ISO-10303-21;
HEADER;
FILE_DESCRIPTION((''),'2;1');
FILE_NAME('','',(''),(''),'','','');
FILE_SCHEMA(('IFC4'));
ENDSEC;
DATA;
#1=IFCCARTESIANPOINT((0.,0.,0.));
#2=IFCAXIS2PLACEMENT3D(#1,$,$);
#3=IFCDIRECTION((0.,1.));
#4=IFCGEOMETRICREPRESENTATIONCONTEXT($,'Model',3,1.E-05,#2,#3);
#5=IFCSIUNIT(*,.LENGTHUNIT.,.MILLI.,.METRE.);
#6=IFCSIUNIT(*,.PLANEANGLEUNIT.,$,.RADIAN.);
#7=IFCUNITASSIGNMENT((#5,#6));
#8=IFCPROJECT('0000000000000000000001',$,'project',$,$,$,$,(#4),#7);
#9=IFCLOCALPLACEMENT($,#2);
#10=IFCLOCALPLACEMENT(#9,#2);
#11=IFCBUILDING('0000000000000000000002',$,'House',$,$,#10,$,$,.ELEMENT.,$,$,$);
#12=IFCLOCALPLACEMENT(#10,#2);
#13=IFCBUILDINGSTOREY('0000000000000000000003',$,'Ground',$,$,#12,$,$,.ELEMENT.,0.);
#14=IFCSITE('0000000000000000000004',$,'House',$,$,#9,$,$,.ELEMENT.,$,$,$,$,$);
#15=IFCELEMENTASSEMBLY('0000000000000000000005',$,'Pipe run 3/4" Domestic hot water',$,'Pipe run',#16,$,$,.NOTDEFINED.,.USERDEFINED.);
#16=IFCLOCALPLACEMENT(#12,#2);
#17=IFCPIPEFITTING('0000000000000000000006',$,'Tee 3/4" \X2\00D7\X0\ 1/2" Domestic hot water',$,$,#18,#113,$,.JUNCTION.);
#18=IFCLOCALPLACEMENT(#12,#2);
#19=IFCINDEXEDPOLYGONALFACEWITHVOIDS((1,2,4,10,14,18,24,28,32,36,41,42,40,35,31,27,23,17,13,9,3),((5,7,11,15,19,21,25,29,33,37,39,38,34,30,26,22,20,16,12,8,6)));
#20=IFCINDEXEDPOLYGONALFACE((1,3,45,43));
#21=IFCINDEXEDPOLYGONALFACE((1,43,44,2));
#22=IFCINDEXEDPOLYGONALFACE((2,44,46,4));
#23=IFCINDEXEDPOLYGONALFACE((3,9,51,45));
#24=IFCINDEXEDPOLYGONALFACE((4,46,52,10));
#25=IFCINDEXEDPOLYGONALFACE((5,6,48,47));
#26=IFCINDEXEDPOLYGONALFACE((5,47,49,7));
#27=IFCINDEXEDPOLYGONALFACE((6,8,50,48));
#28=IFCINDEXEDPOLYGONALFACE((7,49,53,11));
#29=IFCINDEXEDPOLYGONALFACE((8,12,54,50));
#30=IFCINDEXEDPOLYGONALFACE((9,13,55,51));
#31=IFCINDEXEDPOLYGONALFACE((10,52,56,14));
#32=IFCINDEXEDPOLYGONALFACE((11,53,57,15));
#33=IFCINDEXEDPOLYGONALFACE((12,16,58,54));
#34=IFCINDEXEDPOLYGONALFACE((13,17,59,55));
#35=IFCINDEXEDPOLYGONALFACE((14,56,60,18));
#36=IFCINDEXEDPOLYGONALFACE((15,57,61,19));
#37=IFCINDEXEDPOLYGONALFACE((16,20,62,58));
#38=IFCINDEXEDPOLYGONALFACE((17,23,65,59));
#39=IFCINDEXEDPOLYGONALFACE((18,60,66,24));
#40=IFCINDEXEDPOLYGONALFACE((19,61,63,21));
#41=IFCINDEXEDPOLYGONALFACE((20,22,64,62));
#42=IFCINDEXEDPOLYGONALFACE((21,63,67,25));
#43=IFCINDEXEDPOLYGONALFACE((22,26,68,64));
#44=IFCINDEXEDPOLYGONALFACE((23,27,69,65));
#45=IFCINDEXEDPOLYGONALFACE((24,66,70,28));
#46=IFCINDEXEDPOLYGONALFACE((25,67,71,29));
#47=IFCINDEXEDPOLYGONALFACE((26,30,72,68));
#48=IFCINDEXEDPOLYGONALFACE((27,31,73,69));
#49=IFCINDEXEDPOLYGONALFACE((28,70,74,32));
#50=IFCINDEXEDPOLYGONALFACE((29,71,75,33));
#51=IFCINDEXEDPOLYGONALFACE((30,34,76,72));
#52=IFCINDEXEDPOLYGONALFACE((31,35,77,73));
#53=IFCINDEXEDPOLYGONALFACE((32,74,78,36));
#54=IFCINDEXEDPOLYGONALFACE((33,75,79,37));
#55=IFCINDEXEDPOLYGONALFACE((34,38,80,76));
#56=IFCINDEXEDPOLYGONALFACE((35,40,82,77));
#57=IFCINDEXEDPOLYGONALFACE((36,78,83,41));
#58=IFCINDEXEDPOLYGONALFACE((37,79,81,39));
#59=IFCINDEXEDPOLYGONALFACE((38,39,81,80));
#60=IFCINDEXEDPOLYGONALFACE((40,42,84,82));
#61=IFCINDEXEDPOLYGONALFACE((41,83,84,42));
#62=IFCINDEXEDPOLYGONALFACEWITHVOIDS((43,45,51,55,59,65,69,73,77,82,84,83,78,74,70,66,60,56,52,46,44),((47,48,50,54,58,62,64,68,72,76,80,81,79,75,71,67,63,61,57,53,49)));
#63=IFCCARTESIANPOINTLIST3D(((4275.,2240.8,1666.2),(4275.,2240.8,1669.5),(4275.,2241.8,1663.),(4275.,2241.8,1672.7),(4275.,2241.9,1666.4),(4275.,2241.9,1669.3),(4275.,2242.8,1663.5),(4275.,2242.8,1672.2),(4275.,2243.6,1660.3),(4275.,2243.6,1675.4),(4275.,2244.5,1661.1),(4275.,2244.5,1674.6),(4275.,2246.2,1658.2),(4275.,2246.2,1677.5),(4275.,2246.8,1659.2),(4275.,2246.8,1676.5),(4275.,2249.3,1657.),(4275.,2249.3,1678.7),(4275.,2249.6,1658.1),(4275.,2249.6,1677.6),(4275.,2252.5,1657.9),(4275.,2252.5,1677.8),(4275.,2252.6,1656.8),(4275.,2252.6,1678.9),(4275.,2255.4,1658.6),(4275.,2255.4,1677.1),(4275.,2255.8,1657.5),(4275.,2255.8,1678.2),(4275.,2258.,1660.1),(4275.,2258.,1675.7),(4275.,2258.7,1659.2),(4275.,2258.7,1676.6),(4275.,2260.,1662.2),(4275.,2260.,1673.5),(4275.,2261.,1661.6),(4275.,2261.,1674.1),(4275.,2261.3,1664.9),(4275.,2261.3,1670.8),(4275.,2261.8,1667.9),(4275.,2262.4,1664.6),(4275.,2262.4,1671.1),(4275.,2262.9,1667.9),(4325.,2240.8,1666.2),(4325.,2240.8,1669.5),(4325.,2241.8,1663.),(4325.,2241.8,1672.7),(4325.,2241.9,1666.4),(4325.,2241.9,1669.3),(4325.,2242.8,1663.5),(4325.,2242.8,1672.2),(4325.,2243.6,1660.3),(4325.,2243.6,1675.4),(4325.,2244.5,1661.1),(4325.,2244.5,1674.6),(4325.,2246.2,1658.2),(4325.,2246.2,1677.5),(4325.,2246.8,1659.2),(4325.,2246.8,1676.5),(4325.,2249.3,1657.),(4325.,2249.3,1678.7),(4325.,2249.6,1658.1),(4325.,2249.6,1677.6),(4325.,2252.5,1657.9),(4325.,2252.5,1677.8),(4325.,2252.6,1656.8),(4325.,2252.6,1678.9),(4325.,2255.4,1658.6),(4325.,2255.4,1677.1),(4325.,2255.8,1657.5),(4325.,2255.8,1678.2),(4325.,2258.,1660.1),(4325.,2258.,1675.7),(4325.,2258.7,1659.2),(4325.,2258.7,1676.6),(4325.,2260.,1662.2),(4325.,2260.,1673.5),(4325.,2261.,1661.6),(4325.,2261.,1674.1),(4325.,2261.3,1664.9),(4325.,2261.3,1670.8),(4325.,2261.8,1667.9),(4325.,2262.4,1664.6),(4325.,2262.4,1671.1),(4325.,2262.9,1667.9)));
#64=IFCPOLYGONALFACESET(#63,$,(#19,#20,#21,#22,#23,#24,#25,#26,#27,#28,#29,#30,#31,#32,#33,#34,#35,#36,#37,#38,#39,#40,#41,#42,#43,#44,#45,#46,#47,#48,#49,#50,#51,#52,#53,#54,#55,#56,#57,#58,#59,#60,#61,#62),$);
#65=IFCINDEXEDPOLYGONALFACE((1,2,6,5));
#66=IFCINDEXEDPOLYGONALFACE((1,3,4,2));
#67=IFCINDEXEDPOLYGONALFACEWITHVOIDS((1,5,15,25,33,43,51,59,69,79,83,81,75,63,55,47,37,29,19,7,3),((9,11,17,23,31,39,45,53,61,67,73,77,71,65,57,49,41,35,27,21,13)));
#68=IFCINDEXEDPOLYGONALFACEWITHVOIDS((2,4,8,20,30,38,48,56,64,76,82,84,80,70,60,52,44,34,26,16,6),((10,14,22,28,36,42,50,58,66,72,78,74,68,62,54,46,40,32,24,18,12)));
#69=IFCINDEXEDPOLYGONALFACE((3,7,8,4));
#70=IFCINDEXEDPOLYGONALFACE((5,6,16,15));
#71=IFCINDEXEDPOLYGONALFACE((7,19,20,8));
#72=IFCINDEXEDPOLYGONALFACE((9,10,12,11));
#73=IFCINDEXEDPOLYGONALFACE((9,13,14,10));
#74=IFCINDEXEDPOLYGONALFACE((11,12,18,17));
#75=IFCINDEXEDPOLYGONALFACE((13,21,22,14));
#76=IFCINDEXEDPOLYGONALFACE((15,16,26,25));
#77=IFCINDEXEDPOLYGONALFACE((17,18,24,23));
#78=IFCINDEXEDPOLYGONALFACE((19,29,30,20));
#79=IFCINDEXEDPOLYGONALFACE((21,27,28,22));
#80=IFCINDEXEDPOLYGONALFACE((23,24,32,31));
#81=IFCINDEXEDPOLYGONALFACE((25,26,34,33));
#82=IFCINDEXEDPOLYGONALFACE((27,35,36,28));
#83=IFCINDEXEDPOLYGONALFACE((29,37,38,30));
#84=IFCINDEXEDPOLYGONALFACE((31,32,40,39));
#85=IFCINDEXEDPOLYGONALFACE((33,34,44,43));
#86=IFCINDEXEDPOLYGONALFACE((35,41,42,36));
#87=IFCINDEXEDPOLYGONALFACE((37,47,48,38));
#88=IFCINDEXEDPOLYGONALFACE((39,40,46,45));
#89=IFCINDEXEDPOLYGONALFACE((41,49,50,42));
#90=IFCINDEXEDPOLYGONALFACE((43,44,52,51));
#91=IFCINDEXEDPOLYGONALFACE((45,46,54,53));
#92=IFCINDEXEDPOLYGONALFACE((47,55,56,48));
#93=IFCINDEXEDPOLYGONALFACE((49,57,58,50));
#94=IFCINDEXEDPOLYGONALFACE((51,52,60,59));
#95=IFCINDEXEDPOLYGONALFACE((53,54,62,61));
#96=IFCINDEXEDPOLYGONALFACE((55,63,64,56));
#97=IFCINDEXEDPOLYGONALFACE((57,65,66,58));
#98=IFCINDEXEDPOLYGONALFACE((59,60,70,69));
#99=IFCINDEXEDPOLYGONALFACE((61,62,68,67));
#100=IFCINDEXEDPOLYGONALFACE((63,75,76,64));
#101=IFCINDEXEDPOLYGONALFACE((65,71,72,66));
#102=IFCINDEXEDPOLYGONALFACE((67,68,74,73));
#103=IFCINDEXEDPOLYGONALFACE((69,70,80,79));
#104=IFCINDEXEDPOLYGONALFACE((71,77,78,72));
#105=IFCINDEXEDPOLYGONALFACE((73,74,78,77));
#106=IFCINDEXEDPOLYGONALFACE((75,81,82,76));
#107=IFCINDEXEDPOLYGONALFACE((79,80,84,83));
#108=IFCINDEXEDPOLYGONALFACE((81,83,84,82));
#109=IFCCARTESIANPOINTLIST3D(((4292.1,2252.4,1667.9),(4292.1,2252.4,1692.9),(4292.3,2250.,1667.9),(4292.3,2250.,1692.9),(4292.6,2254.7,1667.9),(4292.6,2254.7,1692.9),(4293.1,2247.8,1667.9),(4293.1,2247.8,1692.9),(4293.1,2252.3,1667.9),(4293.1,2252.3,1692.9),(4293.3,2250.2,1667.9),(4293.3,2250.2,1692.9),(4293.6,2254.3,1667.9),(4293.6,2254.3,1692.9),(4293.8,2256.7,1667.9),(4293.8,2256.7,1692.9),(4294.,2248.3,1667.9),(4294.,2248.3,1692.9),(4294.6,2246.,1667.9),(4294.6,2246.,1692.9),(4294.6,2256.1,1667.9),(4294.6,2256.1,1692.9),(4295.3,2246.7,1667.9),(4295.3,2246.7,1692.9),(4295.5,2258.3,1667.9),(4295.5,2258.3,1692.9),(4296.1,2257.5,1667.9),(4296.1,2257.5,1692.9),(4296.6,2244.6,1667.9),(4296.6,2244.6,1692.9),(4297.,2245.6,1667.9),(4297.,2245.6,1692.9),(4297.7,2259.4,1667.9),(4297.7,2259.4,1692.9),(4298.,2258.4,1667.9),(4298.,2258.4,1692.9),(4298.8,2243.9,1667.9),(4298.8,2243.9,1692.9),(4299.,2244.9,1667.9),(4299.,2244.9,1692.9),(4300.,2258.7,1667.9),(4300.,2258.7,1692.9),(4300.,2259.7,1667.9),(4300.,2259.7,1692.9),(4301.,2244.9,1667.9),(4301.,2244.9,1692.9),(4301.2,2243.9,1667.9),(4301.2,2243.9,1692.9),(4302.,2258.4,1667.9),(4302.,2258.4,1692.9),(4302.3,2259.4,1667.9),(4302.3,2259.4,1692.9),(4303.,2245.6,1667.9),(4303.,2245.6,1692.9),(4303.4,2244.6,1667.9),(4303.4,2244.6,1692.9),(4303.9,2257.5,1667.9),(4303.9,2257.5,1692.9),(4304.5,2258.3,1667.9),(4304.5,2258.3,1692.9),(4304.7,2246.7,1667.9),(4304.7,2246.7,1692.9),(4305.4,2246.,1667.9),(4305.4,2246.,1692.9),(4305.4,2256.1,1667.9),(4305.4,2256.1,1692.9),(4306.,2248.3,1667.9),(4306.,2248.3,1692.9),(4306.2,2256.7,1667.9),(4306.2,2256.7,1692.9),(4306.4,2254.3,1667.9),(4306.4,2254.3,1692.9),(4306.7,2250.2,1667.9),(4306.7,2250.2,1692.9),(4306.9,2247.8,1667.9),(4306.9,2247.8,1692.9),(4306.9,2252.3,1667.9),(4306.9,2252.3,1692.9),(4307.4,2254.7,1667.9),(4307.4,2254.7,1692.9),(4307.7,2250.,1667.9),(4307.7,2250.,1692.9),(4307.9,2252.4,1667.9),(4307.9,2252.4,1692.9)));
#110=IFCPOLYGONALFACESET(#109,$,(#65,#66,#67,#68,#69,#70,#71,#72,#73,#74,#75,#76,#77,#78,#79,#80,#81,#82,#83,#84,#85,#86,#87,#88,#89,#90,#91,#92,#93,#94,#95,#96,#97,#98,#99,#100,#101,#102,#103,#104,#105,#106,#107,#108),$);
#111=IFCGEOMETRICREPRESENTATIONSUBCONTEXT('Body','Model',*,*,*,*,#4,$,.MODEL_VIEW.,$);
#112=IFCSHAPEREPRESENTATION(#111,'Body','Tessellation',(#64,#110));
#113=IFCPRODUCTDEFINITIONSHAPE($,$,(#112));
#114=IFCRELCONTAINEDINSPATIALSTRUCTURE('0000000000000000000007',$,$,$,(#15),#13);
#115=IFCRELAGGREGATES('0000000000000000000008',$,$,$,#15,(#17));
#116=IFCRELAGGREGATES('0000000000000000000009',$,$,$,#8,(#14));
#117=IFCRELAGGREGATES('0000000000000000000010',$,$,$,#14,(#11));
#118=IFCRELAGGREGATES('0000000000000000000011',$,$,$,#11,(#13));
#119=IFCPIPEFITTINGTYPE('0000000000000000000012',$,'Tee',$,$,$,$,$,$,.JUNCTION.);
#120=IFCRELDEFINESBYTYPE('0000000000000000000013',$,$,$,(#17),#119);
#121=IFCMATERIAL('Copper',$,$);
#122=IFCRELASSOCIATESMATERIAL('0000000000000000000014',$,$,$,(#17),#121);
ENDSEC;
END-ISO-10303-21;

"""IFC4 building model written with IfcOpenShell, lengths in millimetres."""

from ifc_helpers import new_model, si_unit, direction, frame, origin, origin_with_axes, origin_2d, place, context, subcontext, project, spatial, hollow_circle, extrude, material, type_object, element, aggregate, save


model = new_model("IFC4")

# Units and contexts
model_context = context("Model", 3, precision=1e-05, world=origin(), true_north=direction((0.0, 1.0)))
body_context = subcontext(model_context, "Body", "Model", "MODEL_VIEW")
ifc_project = project(units=[si_unit("LENGTHUNIT", "METRE", prefix="MILLI"), si_unit("PLANEANGLEUNIT", "RADIAN")], contexts=[model_context])

# Site, building, storey
site_placement = place(None, origin())
site = spatial("IfcSite", under=ifc_project, at=site_placement, Name="House", CompositionType="ELEMENT")
building_placement = place(site_placement, origin())
building = spatial("IfcBuilding", under=site, at=building_placement, Name="House", CompositionType="ELEMENT")
storey_placement = place(building_placement, origin())
storey = spatial("IfcBuildingStorey", under=building, at=storey_placement, Name="Ground", CompositionType="ELEMENT", Elevation=0.0)

# Element assembly
ifc_material = material(Name="Copper")
assembly_1_placement = place(storey_placement, origin_with_axes())
assembly_1 = element("IfcElementAssembly", 1, at=assembly_1_placement, inside=storey, Name="Pipe run 3/4\" Domestic hot water", ObjectType="Pipe run", AssemblyPlace="NOTDEFINED", PredefinedType="USERDEFINED")

# Pipe fitting
pipe_fitting_type_1 = type_object("IfcPipeFittingType", Name="Tee", PredefinedType="JUNCTION")
pipe_fitting_1_placement = place(storey_placement, origin_with_axes())
pipe_fitting_1 = element("IfcPipeFitting", 2, at=pipe_fitting_1_placement, type_object=pipe_fitting_type_1, material=ifc_material, Name="Tee 3/4\" × 1/2\" Domestic hot water", PredefinedType="JUNCTION", context=body_context, shape_type="SweptSolid", body=[
    extrude(hollow_circle(Radius=11.1, WallThickness=1.1, at=origin_2d()), frame((4275.0, 2251.8, 1667.9), z_axis=(1.0, 0.0, 0.0), x_axis=(0.0, 1.0, 0.0)), (0.0, 0.0, 1.0), 50.0),
    extrude(hollow_circle(Radius=7.9, WallThickness=1.0, at=origin_2d()), frame((4300.0, 2251.8, 1667.9), z_axis=(0.0, 0.0, 1.0), x_axis=(0.0, 1.0, 0.0)), (0.0, 0.0, 1.0), 25.0),
])
aggregate(assembly_1, [pipe_fitting_1])

save(model, "model.ifc")
